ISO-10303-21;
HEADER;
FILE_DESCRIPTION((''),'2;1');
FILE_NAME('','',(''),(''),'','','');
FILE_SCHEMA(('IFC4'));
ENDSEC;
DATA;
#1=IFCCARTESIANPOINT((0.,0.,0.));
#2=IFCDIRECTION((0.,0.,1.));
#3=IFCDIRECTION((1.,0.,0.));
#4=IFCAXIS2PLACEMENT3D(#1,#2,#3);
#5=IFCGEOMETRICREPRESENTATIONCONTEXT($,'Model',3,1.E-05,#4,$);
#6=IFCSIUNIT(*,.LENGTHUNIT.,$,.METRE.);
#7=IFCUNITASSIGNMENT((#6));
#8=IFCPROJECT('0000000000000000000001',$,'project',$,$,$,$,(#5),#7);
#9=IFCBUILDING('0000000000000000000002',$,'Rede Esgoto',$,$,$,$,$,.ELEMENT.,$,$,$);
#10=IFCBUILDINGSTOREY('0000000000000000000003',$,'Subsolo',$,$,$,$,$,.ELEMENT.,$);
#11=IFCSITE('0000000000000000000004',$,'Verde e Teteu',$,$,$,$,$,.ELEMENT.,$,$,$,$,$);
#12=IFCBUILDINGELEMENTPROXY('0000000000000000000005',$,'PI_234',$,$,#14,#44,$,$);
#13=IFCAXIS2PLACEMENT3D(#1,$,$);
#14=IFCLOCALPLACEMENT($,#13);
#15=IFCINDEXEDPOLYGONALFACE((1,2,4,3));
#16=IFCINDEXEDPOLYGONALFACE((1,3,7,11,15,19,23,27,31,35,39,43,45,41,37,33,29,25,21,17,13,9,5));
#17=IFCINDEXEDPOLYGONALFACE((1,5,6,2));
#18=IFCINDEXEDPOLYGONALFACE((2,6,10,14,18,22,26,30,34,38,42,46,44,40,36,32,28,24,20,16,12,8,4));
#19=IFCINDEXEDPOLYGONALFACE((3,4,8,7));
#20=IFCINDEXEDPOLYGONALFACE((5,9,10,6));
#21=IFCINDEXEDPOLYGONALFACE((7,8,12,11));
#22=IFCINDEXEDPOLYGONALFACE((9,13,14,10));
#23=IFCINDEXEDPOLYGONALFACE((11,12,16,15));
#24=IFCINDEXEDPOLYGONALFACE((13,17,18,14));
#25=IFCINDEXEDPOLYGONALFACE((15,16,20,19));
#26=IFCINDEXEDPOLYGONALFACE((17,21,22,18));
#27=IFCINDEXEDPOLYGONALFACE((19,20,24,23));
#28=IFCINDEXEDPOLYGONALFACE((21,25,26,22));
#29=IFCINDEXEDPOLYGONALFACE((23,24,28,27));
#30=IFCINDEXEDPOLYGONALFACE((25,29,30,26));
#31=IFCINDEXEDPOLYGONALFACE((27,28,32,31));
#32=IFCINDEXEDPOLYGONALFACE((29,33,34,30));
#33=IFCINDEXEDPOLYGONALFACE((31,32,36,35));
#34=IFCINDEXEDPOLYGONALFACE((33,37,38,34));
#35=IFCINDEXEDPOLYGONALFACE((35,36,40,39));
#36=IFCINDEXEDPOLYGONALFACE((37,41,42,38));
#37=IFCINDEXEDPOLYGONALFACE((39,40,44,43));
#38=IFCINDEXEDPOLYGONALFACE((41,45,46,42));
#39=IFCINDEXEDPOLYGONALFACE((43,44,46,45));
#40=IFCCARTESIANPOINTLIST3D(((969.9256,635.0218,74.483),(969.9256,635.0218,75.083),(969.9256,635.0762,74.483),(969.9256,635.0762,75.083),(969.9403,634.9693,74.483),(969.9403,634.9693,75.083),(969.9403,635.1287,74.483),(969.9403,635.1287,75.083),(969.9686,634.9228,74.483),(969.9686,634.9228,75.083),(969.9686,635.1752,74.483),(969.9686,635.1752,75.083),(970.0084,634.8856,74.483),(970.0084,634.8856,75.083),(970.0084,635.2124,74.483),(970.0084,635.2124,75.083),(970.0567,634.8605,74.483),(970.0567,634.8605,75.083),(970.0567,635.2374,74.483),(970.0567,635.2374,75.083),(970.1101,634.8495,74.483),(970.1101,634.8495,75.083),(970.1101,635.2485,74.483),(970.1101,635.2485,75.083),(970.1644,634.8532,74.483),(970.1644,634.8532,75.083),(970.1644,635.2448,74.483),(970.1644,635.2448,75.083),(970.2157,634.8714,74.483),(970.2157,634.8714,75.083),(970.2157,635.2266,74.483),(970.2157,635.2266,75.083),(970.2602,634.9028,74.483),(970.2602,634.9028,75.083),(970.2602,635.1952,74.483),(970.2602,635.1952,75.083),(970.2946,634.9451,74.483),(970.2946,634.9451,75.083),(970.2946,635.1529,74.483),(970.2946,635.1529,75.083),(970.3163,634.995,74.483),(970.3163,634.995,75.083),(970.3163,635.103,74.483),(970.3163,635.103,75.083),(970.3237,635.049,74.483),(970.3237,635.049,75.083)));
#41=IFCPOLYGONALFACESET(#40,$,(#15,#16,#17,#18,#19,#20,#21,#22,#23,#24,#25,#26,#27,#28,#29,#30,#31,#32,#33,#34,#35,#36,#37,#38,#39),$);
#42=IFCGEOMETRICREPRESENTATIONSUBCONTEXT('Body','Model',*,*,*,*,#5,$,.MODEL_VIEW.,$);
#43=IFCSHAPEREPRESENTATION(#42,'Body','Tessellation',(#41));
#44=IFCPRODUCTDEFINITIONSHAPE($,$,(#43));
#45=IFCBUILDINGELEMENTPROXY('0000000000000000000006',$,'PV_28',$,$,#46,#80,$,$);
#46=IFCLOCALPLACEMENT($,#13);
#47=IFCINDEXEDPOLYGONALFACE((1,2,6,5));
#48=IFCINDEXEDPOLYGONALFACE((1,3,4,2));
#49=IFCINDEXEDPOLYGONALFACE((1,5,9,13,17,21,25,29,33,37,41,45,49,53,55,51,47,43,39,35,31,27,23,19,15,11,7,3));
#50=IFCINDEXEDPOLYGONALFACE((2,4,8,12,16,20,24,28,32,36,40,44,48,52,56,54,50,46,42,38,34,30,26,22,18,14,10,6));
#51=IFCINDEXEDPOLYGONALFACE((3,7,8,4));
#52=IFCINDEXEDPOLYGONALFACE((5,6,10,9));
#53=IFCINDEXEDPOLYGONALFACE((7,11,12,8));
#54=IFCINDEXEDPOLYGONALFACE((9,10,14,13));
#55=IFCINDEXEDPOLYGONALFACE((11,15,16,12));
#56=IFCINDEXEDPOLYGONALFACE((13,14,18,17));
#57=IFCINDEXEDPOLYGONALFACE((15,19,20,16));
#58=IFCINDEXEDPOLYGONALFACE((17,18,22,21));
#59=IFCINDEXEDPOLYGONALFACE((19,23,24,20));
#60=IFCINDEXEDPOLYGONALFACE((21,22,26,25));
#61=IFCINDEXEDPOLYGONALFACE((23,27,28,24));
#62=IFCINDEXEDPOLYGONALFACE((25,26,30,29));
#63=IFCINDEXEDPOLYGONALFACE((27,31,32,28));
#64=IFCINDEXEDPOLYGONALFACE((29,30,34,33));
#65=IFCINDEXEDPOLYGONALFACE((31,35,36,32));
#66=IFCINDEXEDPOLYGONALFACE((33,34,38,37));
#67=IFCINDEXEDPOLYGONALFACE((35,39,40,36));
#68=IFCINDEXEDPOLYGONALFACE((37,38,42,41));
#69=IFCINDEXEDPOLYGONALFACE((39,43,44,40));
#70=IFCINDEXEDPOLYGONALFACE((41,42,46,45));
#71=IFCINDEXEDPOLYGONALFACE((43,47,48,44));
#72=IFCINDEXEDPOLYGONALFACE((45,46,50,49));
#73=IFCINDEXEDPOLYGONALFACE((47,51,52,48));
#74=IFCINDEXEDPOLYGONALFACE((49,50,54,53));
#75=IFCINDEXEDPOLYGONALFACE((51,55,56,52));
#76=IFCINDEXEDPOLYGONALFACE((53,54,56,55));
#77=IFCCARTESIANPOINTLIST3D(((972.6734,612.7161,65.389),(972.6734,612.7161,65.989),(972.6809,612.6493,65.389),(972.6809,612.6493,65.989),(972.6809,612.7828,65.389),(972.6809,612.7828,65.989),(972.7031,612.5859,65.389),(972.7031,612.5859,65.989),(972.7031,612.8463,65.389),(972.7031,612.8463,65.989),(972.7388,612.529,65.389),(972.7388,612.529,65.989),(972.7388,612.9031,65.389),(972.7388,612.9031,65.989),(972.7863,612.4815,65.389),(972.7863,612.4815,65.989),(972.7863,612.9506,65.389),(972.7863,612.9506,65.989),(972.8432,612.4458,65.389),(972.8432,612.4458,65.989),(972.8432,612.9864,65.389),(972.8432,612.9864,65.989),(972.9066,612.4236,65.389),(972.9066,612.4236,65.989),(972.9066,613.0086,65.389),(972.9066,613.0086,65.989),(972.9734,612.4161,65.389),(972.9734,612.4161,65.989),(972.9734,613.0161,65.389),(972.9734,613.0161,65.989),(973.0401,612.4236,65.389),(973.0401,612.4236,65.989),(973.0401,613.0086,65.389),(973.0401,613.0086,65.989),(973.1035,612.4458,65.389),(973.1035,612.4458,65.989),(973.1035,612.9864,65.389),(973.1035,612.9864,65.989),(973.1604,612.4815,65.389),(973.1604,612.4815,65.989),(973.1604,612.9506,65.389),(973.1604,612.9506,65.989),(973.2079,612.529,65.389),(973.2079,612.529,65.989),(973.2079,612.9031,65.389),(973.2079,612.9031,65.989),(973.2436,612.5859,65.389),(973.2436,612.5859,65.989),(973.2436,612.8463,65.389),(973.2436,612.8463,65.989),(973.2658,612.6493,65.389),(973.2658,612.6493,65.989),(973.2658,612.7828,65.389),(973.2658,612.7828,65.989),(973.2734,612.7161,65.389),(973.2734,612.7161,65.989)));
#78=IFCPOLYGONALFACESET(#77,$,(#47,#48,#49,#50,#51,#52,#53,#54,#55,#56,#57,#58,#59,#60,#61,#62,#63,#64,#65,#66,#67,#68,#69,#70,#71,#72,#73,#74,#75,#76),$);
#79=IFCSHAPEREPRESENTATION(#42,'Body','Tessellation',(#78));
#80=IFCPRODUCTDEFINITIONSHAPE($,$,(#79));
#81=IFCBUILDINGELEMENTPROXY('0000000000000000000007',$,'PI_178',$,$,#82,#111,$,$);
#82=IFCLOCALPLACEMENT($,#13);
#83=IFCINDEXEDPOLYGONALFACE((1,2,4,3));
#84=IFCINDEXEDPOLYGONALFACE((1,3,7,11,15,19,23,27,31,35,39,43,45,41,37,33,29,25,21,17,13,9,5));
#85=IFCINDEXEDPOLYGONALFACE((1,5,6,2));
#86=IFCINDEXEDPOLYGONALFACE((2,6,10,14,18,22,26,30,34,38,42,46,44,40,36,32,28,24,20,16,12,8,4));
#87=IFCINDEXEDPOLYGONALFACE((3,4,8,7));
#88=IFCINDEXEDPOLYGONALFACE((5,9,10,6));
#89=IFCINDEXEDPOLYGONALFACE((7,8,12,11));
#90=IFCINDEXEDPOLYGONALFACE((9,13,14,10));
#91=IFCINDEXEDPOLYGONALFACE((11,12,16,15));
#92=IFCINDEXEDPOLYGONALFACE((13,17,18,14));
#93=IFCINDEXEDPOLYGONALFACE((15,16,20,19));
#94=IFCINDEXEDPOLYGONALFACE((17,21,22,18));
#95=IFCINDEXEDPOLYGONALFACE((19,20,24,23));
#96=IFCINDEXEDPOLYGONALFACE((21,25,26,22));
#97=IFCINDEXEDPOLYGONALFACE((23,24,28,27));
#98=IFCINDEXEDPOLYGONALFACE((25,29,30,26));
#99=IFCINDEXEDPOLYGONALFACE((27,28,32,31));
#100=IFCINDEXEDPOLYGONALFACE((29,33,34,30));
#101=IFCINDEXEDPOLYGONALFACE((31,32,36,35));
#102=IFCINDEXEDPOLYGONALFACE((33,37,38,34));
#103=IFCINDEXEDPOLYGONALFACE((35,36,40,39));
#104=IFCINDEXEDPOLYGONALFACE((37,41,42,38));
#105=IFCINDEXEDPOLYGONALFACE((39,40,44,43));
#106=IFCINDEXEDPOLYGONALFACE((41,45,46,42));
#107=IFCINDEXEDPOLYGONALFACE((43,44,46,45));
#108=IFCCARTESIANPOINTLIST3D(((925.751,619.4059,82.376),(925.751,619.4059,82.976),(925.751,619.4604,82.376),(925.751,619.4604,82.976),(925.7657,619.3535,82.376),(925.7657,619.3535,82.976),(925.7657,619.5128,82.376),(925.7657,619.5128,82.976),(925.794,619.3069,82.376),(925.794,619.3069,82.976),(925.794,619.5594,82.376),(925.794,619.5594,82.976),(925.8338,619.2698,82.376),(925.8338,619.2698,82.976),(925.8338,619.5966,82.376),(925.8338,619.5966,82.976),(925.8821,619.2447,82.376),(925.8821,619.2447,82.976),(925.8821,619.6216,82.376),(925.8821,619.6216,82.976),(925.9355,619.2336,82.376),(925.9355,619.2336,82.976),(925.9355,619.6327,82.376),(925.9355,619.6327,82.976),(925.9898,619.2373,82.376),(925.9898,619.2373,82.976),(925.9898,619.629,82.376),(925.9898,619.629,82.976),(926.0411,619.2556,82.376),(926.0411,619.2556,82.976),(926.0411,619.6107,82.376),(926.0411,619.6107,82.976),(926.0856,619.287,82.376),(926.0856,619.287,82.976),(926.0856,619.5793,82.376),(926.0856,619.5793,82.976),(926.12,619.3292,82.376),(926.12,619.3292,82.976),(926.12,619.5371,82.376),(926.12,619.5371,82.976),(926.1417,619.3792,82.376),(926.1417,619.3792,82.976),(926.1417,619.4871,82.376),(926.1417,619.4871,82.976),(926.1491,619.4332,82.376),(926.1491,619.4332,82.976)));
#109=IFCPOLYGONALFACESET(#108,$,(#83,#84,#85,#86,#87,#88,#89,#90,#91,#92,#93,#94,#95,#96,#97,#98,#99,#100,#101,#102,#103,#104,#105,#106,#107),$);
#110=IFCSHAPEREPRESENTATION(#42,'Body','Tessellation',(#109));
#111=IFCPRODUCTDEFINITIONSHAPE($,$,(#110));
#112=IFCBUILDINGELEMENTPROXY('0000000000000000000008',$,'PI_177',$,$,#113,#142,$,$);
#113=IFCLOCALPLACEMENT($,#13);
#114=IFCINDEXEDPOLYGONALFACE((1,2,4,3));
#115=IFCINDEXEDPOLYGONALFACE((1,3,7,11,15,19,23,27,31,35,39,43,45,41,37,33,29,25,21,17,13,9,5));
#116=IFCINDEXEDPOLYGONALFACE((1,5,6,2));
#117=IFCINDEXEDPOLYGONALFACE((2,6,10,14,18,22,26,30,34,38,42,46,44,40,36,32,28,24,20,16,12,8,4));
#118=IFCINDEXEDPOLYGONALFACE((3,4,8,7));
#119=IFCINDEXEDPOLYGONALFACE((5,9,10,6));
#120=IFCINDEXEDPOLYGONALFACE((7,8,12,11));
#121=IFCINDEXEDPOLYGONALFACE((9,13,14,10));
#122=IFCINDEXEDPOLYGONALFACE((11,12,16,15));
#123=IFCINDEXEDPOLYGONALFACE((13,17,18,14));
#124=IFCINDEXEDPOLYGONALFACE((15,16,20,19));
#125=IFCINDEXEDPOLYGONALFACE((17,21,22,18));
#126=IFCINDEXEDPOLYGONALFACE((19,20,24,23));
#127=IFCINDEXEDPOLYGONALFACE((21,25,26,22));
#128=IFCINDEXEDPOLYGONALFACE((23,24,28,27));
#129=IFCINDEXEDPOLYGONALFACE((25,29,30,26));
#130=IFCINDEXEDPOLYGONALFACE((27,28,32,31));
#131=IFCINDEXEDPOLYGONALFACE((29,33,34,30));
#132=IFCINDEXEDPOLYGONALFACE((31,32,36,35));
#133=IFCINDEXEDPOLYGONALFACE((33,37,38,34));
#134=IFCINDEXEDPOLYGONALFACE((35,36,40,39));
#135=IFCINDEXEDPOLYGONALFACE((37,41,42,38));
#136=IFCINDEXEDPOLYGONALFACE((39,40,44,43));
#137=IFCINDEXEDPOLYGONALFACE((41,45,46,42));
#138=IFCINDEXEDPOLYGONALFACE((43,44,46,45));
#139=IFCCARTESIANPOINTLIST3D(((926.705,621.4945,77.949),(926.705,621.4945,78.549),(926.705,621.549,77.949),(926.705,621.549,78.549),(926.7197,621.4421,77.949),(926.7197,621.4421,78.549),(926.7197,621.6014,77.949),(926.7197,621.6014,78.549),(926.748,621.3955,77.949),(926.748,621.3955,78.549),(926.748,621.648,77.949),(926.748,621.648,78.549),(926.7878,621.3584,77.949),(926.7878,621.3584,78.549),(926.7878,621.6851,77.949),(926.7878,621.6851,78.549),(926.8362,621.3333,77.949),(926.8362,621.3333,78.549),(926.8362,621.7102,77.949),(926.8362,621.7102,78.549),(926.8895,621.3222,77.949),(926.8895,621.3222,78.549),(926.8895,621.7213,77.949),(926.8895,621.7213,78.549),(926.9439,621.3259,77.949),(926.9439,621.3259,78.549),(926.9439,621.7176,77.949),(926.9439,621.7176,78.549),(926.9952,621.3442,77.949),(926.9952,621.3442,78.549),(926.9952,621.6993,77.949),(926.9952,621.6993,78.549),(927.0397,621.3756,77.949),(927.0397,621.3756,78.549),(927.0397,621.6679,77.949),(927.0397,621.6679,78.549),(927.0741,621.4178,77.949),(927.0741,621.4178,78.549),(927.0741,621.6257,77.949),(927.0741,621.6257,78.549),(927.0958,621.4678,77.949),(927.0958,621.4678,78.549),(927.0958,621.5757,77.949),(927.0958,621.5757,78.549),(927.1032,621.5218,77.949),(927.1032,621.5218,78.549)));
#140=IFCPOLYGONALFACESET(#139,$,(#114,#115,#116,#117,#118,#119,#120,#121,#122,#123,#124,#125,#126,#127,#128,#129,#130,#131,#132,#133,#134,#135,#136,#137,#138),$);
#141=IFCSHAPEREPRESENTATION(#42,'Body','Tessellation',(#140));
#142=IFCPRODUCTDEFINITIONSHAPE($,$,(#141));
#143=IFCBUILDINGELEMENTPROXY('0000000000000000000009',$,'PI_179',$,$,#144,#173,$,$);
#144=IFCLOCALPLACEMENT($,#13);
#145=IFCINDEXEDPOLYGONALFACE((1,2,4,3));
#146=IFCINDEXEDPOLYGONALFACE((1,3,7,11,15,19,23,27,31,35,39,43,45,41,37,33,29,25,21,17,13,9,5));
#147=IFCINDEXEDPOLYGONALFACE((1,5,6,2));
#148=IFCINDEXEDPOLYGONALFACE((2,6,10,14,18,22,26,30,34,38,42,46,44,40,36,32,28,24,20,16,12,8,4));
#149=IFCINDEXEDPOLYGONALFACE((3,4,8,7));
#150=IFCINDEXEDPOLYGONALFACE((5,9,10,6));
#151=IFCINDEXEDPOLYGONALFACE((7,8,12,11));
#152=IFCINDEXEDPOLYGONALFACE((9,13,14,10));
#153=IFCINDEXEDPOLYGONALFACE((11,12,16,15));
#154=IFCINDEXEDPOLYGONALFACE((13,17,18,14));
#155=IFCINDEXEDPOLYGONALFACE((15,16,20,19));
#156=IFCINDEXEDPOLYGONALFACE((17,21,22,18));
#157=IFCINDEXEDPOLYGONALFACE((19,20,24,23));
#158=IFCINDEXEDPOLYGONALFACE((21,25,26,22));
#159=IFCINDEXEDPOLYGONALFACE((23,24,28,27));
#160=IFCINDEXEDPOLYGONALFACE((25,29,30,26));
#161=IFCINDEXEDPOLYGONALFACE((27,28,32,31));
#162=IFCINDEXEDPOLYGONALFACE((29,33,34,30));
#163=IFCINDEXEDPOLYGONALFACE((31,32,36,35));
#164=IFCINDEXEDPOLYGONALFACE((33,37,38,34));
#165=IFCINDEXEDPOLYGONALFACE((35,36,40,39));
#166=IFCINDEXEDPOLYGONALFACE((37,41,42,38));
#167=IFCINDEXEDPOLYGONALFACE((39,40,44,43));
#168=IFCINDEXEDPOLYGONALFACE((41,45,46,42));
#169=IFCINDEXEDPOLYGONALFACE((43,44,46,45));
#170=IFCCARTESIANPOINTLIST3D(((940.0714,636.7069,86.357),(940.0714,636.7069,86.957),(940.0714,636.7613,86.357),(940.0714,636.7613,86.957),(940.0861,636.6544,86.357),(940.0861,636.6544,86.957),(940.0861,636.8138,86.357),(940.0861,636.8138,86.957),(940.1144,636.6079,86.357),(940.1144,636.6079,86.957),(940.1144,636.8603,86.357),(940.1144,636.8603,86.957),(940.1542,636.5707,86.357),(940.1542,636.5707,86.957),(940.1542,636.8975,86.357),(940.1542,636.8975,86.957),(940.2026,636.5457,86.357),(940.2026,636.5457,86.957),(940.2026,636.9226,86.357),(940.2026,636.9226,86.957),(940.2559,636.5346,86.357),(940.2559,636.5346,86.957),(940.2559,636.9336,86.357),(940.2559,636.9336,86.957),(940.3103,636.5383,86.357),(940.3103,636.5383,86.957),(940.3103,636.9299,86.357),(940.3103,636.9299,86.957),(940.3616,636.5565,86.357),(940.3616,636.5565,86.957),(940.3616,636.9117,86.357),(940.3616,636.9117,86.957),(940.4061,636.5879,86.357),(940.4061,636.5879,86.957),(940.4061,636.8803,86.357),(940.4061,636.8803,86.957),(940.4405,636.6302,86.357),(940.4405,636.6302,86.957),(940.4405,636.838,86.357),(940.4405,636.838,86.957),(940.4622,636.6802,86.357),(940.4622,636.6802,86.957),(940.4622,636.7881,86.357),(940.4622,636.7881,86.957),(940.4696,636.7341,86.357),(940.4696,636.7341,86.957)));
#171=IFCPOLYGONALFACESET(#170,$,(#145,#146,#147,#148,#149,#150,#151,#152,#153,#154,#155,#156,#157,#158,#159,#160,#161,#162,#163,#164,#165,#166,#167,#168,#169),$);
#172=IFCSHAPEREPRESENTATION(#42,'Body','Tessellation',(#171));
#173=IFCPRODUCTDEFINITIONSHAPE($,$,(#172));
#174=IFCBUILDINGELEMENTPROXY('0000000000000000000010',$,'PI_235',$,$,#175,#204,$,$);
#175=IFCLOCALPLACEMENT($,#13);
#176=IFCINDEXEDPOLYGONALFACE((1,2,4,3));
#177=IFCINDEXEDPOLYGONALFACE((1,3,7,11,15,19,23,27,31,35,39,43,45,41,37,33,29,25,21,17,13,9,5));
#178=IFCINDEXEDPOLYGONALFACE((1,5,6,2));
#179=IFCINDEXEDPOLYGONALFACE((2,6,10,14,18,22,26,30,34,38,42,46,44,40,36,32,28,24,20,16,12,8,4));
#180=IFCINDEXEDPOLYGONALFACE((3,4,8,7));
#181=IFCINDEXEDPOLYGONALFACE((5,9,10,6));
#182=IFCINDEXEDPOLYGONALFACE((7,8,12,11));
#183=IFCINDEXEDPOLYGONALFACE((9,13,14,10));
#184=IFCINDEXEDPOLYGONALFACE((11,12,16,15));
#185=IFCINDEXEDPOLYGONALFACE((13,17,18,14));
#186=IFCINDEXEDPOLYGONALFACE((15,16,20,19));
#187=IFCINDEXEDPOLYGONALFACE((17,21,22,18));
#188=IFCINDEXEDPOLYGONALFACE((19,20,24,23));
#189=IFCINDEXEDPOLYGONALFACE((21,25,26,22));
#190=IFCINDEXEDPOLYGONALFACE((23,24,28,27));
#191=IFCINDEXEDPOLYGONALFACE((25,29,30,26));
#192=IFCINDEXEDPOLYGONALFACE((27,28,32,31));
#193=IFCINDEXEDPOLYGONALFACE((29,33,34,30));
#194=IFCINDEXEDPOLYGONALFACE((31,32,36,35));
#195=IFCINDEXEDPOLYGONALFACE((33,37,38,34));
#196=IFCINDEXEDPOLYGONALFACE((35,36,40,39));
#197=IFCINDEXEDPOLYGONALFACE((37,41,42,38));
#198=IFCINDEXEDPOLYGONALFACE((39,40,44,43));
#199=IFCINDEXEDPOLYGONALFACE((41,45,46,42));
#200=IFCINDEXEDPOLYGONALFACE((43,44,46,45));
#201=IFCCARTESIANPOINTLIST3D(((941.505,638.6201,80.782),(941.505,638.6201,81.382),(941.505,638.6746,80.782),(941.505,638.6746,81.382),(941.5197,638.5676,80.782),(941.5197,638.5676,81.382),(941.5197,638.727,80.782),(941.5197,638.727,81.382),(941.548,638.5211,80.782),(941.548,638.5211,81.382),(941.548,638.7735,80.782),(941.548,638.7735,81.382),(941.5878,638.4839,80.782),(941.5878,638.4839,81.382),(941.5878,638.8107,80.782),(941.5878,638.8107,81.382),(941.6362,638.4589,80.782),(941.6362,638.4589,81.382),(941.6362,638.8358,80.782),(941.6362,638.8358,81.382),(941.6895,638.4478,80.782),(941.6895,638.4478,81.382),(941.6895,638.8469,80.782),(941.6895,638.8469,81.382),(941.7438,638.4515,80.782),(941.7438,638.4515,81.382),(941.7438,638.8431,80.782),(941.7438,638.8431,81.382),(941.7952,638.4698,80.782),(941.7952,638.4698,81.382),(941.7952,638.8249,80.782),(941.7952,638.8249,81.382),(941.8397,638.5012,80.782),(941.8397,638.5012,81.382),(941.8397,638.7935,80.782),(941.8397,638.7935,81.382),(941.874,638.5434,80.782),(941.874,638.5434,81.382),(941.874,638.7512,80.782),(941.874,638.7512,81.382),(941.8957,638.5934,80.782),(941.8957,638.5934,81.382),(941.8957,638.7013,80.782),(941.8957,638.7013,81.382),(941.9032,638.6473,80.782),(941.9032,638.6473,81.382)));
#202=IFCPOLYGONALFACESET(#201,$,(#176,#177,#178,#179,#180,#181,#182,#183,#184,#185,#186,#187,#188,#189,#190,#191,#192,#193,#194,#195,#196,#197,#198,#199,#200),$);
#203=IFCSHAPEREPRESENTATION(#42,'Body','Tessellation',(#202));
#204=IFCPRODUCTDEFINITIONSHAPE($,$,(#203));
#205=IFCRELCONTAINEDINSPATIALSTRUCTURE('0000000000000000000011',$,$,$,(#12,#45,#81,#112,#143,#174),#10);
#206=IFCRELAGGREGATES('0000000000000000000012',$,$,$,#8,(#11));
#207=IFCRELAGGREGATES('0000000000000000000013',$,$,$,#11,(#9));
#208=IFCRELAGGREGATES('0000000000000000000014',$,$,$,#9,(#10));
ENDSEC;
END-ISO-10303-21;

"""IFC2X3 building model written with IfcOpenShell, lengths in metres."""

from ifc_helpers import new_model, si_unit, frame, origin_with_axes, origin_2d, place, context, subcontext, project, spatial, circle, extrude, element, save


model = new_model("IFC2X3")

# Units and contexts
model_context = context("Model", 3, precision=1e-05, world=origin_with_axes())
body_context = subcontext(model_context, "Body", "Model", "MODEL_VIEW")
ifc_project = project(units=[si_unit("LENGTHUNIT", "METRE")], contexts=[model_context])

# Site, building, storey
site = spatial("IfcSite", under=ifc_project, Name="Verde e Teteu", CompositionType="ELEMENT")
building = spatial("IfcBuilding", under=site, Name="Rede Esgoto", CompositionType="ELEMENT")
storey = spatial("IfcBuildingStorey", under=building, Name="Subsolo", CompositionType="ELEMENT")

# Building element proxies
proxy_1_placement = place(None, frame((970.1237, 635.049, 74.483), z_axis=(0.0, 0.0, 1.0), x_axis=(1.0, 0.0, 0.0)))
element("IfcBuildingElementProxy", 1, at=proxy_1_placement, inside=storey, Name="PI_234", context=body_context, shape_type="SweptSolid", body=[
    extrude(circle(Radius=0.2, at=origin_2d()), origin_with_axes(), (0.0, 0.0, 1.0), 0.6),
])
proxy_2_placement = place(None, frame((972.9734, 612.7161, 65.389), z_axis=(0.0, 0.0, 1.0), x_axis=(1.0, 0.0, 0.0)))
element("IfcBuildingElementProxy", 2, at=proxy_2_placement, inside=storey, Name="PV_28", context=body_context, shape_type="SweptSolid", body=[
    extrude(circle(Radius=0.3, at=origin_2d()), origin_with_axes(), (0.0, 0.0, 1.0), 0.6),
])
proxy_3_placement = place(None, frame((925.9491, 619.4332, 82.376), z_axis=(0.0, 0.0, 1.0), x_axis=(1.0, 0.0, 0.0)))
element("IfcBuildingElementProxy", 3, at=proxy_3_placement, inside=storey, Name="PI_178", context=body_context, shape_type="SweptSolid", body=[
    extrude(circle(Radius=0.2, at=origin_2d()), origin_with_axes(), (0.0, 0.0, 1.0), 0.6),
])
proxy_4_placement = place(None, frame((926.9032, 621.5218, 77.949), z_axis=(0.0, 0.0, 1.0), x_axis=(1.0, 0.0, 0.0)))
element("IfcBuildingElementProxy", 4, at=proxy_4_placement, inside=storey, Name="PI_177", context=body_context, shape_type="SweptSolid", body=[
    extrude(circle(Radius=0.2, at=origin_2d()), origin_with_axes(), (0.0, 0.0, 1.0), 0.6),
])
proxy_5_placement = place(None, frame((940.2696, 636.7341, 86.357), z_axis=(0.0, 0.0, 1.0), x_axis=(1.0, 0.0, 0.0)))
element("IfcBuildingElementProxy", 5, at=proxy_5_placement, inside=storey, Name="PI_179", context=body_context, shape_type="SweptSolid", body=[
    extrude(circle(Radius=0.2, at=origin_2d()), origin_with_axes(), (0.0, 0.0, 1.0), 0.6),
])
proxy_6_placement = place(None, frame((941.7032, 638.6473, 80.782), z_axis=(0.0, 0.0, 1.0), x_axis=(1.0, 0.0, 0.0)))
element("IfcBuildingElementProxy", 6, at=proxy_6_placement, inside=storey, Name="PI_235", context=body_context, shape_type="SweptSolid", body=[
    extrude(circle(Radius=0.2, at=origin_2d()), origin_with_axes(), (0.0, 0.0, 1.0), 0.6),
])

save(model, "model.ifc")
